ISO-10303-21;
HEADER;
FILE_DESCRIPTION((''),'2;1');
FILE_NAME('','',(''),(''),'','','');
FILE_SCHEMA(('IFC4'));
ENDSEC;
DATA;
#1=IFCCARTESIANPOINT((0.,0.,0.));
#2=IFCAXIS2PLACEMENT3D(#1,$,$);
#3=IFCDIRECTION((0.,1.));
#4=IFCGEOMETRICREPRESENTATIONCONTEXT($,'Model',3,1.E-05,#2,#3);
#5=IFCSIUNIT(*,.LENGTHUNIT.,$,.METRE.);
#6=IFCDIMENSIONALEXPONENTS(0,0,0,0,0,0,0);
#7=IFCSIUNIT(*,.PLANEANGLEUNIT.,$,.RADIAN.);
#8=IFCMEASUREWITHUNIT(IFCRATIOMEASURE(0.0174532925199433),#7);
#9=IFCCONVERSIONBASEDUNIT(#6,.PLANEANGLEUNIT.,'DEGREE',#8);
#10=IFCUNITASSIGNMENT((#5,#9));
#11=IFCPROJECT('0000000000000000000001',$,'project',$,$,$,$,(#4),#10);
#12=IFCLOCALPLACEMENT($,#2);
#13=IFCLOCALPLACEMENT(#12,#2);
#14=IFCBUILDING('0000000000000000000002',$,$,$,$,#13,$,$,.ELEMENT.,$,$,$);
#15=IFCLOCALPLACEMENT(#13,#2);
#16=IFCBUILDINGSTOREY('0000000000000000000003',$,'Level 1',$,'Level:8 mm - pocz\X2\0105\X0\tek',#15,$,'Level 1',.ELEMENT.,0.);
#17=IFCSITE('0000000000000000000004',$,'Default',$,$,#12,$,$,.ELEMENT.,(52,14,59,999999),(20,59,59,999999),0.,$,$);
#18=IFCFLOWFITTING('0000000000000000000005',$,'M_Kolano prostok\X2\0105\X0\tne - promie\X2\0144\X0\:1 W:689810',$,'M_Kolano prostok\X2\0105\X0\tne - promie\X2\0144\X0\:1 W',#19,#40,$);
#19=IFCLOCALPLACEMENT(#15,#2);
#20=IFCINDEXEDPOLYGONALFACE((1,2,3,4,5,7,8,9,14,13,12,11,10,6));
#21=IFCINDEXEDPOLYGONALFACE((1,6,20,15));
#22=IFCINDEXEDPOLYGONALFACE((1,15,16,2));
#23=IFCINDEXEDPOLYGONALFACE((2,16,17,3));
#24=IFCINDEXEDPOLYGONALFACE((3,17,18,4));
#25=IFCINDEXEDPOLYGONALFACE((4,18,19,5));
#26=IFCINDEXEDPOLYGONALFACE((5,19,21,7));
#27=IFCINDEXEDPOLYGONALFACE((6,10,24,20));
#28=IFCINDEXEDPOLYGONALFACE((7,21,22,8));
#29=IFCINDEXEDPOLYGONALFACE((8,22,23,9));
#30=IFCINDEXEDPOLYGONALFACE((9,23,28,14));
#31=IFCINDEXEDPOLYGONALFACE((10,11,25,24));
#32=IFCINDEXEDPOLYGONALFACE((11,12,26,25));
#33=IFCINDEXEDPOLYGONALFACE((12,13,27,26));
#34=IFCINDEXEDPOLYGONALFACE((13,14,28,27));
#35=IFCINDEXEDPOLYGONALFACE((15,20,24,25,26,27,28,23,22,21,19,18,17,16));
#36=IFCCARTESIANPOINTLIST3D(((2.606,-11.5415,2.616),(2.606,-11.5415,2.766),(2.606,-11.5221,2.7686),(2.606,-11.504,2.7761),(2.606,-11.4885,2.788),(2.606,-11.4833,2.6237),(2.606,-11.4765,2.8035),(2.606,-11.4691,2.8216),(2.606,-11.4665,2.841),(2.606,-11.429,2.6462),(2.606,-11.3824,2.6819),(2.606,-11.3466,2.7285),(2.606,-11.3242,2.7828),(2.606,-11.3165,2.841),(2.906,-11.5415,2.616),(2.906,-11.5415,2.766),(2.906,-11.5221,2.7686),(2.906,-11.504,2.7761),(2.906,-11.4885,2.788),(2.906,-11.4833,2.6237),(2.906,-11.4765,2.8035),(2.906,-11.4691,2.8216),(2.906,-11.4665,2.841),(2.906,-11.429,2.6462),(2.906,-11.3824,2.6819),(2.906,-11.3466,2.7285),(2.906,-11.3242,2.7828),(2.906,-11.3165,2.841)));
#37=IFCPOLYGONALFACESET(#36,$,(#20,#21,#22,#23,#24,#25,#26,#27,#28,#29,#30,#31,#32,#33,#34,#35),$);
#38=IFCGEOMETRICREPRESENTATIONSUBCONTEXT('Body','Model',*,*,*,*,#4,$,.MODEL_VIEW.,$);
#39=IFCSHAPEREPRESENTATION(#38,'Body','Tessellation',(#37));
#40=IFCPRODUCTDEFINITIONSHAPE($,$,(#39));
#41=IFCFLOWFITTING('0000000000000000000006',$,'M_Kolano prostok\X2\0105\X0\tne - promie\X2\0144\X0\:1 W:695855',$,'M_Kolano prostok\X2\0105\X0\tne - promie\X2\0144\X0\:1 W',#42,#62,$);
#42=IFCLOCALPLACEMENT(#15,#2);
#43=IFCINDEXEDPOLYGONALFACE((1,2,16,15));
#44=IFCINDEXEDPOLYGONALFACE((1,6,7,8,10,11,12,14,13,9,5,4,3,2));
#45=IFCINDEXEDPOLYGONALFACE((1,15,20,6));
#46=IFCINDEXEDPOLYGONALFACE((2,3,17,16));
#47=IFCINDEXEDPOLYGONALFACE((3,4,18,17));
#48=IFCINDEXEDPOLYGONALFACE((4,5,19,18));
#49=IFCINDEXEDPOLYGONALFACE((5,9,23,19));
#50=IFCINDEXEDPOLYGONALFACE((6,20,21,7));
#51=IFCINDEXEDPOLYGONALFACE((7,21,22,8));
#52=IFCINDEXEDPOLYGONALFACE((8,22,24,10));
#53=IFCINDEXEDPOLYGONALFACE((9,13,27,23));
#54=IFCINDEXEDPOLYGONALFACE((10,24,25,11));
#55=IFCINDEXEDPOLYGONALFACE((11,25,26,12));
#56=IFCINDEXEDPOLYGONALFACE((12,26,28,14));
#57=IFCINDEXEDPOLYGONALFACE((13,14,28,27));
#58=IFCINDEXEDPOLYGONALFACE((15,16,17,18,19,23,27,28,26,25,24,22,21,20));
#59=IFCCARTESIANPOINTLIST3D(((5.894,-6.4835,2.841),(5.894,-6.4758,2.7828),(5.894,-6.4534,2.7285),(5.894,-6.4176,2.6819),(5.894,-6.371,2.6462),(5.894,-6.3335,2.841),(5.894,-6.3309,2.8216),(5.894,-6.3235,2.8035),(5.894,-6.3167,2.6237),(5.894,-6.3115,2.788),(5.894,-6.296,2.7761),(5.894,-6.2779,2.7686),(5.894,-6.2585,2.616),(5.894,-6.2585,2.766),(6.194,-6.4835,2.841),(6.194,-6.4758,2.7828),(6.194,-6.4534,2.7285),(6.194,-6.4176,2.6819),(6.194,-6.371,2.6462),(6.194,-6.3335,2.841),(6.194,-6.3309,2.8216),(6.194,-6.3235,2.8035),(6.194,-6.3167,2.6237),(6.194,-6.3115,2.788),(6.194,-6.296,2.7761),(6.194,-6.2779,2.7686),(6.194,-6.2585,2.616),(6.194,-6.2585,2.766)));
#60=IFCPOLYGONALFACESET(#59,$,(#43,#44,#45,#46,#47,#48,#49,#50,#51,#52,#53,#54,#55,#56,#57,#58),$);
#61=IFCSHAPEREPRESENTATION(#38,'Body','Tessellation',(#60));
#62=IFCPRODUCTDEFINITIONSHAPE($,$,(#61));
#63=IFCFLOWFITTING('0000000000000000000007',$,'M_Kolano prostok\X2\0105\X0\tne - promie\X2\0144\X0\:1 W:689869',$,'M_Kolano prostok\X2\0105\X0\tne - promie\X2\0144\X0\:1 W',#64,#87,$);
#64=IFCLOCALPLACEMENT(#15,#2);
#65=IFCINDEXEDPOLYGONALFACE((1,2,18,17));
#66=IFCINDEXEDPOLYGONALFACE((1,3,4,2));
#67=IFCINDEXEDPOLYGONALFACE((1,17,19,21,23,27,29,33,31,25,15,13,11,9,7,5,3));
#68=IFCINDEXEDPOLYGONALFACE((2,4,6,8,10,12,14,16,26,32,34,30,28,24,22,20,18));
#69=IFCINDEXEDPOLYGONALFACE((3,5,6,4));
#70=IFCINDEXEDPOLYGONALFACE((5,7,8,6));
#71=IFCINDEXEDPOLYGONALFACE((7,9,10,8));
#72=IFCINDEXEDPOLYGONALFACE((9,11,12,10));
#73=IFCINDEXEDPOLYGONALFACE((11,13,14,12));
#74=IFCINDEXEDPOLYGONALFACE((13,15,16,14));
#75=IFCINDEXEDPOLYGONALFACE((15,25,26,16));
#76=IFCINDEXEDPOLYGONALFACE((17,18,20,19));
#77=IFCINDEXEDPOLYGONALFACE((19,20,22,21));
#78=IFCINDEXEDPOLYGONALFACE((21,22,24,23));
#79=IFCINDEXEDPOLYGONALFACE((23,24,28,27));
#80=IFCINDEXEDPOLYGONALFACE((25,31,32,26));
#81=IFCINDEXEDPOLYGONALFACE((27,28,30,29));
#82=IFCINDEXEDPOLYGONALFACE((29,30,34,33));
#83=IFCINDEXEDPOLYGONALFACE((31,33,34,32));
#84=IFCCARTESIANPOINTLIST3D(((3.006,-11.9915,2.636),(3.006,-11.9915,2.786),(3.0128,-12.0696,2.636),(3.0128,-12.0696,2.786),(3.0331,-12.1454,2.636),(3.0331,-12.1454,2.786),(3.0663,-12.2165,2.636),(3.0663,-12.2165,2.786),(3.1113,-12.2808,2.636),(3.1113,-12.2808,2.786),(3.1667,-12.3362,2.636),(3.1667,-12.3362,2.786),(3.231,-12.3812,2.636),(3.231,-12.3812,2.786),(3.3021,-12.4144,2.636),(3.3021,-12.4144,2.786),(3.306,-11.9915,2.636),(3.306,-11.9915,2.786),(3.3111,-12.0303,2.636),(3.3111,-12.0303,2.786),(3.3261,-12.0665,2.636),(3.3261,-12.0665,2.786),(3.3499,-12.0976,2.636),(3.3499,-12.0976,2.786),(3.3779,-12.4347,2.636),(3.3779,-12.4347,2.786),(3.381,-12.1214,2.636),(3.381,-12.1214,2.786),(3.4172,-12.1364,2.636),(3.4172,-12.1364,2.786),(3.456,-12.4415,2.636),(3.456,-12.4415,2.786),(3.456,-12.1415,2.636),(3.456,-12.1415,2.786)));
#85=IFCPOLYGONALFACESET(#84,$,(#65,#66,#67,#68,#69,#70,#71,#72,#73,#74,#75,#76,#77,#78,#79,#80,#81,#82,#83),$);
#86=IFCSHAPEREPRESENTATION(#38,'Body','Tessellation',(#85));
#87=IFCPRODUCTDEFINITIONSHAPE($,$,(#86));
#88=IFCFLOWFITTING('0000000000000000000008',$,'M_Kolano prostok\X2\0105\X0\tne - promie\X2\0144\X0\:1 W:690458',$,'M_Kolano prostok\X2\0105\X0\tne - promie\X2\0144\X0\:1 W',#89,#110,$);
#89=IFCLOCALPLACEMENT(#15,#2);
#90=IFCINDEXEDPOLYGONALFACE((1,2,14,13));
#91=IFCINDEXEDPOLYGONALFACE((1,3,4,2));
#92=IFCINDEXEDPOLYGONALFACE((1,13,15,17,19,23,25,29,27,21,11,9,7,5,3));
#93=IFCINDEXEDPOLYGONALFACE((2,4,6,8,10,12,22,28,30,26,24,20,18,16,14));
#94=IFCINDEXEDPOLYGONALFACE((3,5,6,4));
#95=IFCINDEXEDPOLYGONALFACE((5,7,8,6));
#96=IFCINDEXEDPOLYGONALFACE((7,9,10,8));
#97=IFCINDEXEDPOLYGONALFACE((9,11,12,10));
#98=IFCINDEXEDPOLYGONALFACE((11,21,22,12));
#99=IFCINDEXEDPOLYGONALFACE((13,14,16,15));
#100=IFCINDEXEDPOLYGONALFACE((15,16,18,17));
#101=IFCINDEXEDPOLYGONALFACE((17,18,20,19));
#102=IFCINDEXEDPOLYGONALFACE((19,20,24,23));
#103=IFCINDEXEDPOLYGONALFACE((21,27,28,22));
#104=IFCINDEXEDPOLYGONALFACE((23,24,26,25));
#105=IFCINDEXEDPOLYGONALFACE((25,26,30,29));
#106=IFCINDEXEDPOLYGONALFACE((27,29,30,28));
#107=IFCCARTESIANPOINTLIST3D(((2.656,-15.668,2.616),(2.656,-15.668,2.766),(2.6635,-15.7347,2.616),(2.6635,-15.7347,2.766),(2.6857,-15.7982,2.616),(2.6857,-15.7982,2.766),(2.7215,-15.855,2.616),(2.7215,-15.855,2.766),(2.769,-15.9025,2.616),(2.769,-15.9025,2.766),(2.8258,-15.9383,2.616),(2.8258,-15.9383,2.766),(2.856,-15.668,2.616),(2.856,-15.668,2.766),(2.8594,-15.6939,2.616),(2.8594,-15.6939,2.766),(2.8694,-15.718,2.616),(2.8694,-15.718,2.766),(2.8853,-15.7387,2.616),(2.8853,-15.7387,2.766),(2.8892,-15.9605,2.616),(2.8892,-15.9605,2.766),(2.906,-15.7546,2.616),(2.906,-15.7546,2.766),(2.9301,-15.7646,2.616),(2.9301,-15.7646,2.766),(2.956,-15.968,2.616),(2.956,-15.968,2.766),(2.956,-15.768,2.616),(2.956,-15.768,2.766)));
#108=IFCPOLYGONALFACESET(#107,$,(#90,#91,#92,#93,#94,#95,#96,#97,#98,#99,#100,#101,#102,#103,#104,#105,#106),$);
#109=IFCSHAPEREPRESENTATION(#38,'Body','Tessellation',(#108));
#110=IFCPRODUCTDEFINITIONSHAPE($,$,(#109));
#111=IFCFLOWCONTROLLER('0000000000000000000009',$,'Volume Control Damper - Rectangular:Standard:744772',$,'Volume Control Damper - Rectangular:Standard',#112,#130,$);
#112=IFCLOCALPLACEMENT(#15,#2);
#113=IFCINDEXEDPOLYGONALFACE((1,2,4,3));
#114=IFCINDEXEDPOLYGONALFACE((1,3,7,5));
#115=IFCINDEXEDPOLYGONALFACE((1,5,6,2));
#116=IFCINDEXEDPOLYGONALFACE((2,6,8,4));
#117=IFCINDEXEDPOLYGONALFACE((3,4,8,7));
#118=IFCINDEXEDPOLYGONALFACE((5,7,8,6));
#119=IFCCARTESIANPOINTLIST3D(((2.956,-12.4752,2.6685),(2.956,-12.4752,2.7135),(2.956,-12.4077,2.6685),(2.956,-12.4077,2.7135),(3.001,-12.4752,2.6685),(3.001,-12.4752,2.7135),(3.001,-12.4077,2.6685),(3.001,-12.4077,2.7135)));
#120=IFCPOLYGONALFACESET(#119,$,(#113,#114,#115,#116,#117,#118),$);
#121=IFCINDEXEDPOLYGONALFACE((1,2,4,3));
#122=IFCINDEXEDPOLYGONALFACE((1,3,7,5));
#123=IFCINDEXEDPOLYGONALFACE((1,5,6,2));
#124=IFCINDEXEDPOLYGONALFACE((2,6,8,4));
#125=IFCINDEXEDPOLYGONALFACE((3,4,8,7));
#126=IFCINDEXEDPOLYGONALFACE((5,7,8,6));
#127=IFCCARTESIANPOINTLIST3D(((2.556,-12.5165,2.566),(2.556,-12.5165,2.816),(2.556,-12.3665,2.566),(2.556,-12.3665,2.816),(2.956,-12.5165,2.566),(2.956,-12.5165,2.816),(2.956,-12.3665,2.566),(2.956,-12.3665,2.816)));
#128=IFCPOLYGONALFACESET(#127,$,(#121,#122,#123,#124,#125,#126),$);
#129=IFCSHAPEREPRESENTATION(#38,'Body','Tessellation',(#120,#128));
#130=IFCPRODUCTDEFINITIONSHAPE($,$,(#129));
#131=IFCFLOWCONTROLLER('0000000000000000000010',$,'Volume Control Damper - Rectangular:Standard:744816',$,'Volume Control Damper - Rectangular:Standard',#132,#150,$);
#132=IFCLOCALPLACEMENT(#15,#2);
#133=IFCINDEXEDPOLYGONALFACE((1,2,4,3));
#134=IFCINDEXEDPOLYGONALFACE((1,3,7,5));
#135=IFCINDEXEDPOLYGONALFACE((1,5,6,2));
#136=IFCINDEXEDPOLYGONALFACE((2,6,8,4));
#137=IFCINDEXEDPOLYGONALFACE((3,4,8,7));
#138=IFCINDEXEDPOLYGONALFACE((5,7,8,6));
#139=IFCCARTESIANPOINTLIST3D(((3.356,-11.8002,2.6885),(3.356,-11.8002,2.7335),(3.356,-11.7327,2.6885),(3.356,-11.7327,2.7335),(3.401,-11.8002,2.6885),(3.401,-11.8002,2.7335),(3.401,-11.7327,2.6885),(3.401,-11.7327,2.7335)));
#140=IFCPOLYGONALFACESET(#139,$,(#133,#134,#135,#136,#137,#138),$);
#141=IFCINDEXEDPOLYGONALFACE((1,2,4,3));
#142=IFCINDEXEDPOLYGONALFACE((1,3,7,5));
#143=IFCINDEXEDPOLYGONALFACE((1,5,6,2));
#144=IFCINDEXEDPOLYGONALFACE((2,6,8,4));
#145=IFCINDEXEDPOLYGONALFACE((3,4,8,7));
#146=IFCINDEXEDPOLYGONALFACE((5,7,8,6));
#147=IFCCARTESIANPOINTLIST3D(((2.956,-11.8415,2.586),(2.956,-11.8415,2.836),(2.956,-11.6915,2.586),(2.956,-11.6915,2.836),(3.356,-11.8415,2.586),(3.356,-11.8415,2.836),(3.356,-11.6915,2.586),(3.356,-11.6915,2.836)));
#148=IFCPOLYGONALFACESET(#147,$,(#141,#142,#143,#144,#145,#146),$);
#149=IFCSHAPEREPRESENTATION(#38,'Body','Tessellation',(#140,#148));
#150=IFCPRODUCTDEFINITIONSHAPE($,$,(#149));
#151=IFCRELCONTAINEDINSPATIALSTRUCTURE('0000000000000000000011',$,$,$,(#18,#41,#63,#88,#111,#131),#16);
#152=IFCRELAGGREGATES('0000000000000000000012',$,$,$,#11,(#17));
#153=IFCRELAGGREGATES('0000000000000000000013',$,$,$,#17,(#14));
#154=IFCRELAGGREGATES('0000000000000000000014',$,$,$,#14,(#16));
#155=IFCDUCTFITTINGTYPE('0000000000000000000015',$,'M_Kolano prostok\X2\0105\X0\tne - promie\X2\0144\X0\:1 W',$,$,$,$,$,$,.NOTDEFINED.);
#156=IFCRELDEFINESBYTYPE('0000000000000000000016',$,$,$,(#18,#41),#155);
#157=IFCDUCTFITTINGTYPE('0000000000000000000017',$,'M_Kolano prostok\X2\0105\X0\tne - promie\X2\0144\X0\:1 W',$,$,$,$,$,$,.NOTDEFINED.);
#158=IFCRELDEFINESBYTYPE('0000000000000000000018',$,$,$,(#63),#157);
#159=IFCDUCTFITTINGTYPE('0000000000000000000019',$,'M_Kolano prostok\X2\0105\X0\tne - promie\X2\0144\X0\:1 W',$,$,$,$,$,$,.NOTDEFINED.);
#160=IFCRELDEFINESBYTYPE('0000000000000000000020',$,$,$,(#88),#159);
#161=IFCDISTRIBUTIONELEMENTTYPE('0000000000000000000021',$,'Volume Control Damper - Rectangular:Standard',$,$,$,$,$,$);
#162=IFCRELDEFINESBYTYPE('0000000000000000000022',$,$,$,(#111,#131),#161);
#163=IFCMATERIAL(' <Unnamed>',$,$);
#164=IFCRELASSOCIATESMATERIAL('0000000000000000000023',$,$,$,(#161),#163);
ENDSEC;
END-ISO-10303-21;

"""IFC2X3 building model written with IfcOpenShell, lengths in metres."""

from ifc_helpers import new_model, entity, si_unit, converted_unit, direction, frame, frame_2d, origin, origin_2d_with_axis, place, context, subcontext, project, spatial, polyline, circle_curve, parameter, trimmed, segment, composite_curve, rectangle, outline, extrude, source, transform, mapped, material, type_object, type_shapes, element, save


model = new_model("IFC2X3")

# Units and contexts
model_context = context("Model", 3, precision=1e-05, world=origin(), true_north=direction((0.0, 1.0)))
body_context = subcontext(model_context, "Body", "Model", "MODEL_VIEW")
ifc_project = project(units=[si_unit("LENGTHUNIT", "METRE"), converted_unit("PLANEANGLEUNIT", "DEGREE", entity("IfcRatioMeasure", 0.0174532925199433), si_unit("PLANEANGLEUNIT", "RADIAN"), dimensions=[0, 0, 0, 0, 0, 0, 0])], contexts=[model_context])

# Site, building, storey
site_placement = place(None, origin())
site = spatial("IfcSite", under=ifc_project, at=site_placement, Name="Default", CompositionType="ELEMENT", RefLatitude=(52, 14, 59, 999999), RefLongitude=(20, 59, 59, 999999), RefElevation=0.0)
building_placement = place(site_placement, origin())
building = spatial("IfcBuilding", under=site, at=building_placement, CompositionType="ELEMENT")
storey_placement = place(building_placement, origin())
storey = spatial("IfcBuildingStorey", under=building, at=storey_placement, Name="Level 1", ObjectType="Level:8 mm - początek", LongName="Level 1", CompositionType="ELEMENT", Elevation=0.0)

# Flow fittings
duct_fitting_type_1 = type_object("IfcDuctFittingType", Name="M_Kolano prostokątne - promień:1 W", PredefinedType="NOTDEFINED")
shared_shape_1 = source(origin(), body_context, "Body", "SweptSolid", [
    extrude(outline(composite_curve([segment(polyline([(-0.15, -0.075), (0.0, -0.075)]), True, "CONTINUOUS"), segment(trimmed(circle_curve(frame_2d((0.075, -0.075), x_axis=(0.0, 1.0)), 0.075), [parameter(0.0)], [parameter(90.0)], True, "PARAMETER"), False, "CONTINUOUS"), segment(polyline([(0.075, 0.0), (0.075, 0.15)]), True, "CONTINUOUS"), segment(trimmed(circle_curve(frame_2d((0.075, -0.075), x_axis=(0.0, 1.0)), 0.225), [parameter(0.0)], [parameter(90.0)], True, "PARAMETER"), True, "CONTINUOUS")], self_intersect=False)), frame((-0.075, 0.075, -0.15), z_axis=(0.0, 0.0, 1.0), x_axis=(-1.0, 0.0, 0.0)), (0.0, 0.0, 1.0), 0.3),
])
type_shapes(duct_fitting_type_1, [shared_shape_1])
for number, where, z_axis, x_axis, name in (
    (1, (2.756, -11.3915, 2.691), (1.0, 0.0, 0.0), (0.0, 1.0, 0.0), "M_Kolano prostokątne - promień:1 W:689810"),
    (2, (6.044, -6.4085, 2.691), (-1.0, 0.0, 0.0), (0.0, -1.0, 0.0), "M_Kolano prostokątne - promień:1 W:695855"),
):
    element("IfcFlowFitting", number, at=place(storey_placement, frame(where, z_axis=z_axis, x_axis=x_axis)), inside=storey, type_object=duct_fitting_type_1, Name=name, ObjectType="M_Kolano prostokątne - promień:1 W", context=body_context, shape_type="MappedRepresentation", body=[
        mapped(shared_shape_1, transform((0.0, 0.0, 0.0), scale=1.0)),
    ])
duct_fitting_type_2 = type_object("IfcDuctFittingType", Name="M_Kolano prostokątne - promień:1 W", PredefinedType="NOTDEFINED")
shared_shape_2 = source(origin(), body_context, "Body", "SweptSolid", [
    extrude(outline(composite_curve([segment(polyline([(-0.3, -0.15), (0.0, -0.15)]), True, "CONTINUOUS"), segment(trimmed(circle_curve(frame_2d((0.15, -0.15), x_axis=(0.0, 1.0)), 0.15), [parameter(0.0)], [parameter(90.0)], True, "PARAMETER"), False, "CONTINUOUS"), segment(polyline([(0.15, 0.0), (0.15, 0.3)]), True, "CONTINUOUS"), segment(trimmed(circle_curve(frame_2d((0.15, -0.15), x_axis=(0.0, 1.0)), 0.45), [parameter(0.0)], [parameter(90.0)], True, "PARAMETER"), True, "CONTINUOUS")], self_intersect=False)), frame((-0.15, 0.15, -0.075), z_axis=(0.0, 0.0, 1.0), x_axis=(-1.0, 0.0, 0.0)), (0.0, 0.0, 1.0), 0.15),
])
type_shapes(duct_fitting_type_2, [shared_shape_2])
flow_fitting_1_placement = place(storey_placement, frame((3.156, -12.2915, 2.711), z_axis=(0.0, 0.0, 1.0), x_axis=(0.0, -1.0, 0.0)))
element("IfcFlowFitting", 3, at=flow_fitting_1_placement, inside=storey, type_object=duct_fitting_type_2, Name="M_Kolano prostokątne - promień:1 W:689869", ObjectType="M_Kolano prostokątne - promień:1 W", context=body_context, shape_type="MappedRepresentation", body=[
    mapped(shared_shape_2, transform((0.0, 0.0, 0.0), scale=1.0)),
])
duct_fitting_type_3 = type_object("IfcDuctFittingType", Name="M_Kolano prostokątne - promień:1 W", PredefinedType="NOTDEFINED")
shared_shape_3 = source(origin(), body_context, "Body", "SweptSolid", [
    extrude(outline(composite_curve([segment(polyline([(-0.2, -0.1), (0.0, -0.1)]), True, "CONTINUOUS"), segment(trimmed(circle_curve(frame_2d((0.1, -0.1), x_axis=(0.0, 1.0)), 0.1), [parameter(0.0)], [parameter(90.0)], True, "PARAMETER"), False, "CONTINUOUS"), segment(polyline([(0.1, 0.0), (0.1, 0.2)]), True, "CONTINUOUS"), segment(trimmed(circle_curve(frame_2d((0.1, -0.1), x_axis=(0.0, 1.0)), 0.3), [parameter(0.0)], [parameter(90.0)], True, "PARAMETER"), True, "CONTINUOUS")], self_intersect=False)), frame((-0.1, 0.1, -0.075), z_axis=(0.0, 0.0, 1.0), x_axis=(-1.0, 0.0, 0.0)), (0.0, 0.0, 1.0), 0.15),
])
type_shapes(duct_fitting_type_3, [shared_shape_3])
flow_fitting_2_placement = place(storey_placement, frame((2.756, -15.868, 2.691), z_axis=(0.0, 0.0, 1.0), x_axis=(0.0, -1.0, 0.0)))
element("IfcFlowFitting", 4, at=flow_fitting_2_placement, inside=storey, type_object=duct_fitting_type_3, Name="M_Kolano prostokątne - promień:1 W:690458", ObjectType="M_Kolano prostokątne - promień:1 W", context=body_context, shape_type="MappedRepresentation", body=[
    mapped(shared_shape_3, transform((0.0, 0.0, 0.0), scale=1.0)),
])

# Flow controllers
ifc_material = material(Name=" <Unnamed>")
distribution_element_type = type_object("IfcDistributionElementType", Name="Volume Control Damper - Rectangular:Standard", material=ifc_material)
shared_shape_4 = source(origin(), body_context, "Body", "SweptSolid", [
    extrude(rectangle(XDim=0.0675, YDim=0.045, at=origin_2d_with_axis()), frame((0.0, 0.2225, -0.0225), z_axis=(0.0, 0.0, 1.0), x_axis=(-1.0, 0.0, 0.0)), (0.0, 0.0, 1.0), 0.045),
    extrude(rectangle(XDim=0.15, YDim=0.4, at=origin_2d_with_axis()), frame((0.0, 0.0, -0.125), z_axis=(0.0, 0.0, 1.0), x_axis=(-1.0, 0.0, 0.0)), (0.0, 0.0, 1.0), 0.25),
])
type_shapes(distribution_element_type, [shared_shape_4])
for number, where, z_axis, x_axis, name in (
    (5, (2.756, -12.4415, 2.691), (0.0, 0.0, -1.0), (0.0, 1.0, 0.0), "Volume Control Damper - Rectangular:Standard:744772"),
    (6, (3.156, -11.7665, 2.711), (0.0, 0.0, -1.0), (0.0, 1.0, 0.0), "Volume Control Damper - Rectangular:Standard:744816"),
):
    element("IfcFlowController", number, at=place(storey_placement, frame(where, z_axis=z_axis, x_axis=x_axis)), inside=storey, type_object=distribution_element_type, Name=name, ObjectType="Volume Control Damper - Rectangular:Standard", context=body_context, shape_type="MappedRepresentation", body=[
        mapped(shared_shape_4, transform((0.0, 0.0, 0.0), scale=1.0)),
    ])

save(model, "model.ifc")
